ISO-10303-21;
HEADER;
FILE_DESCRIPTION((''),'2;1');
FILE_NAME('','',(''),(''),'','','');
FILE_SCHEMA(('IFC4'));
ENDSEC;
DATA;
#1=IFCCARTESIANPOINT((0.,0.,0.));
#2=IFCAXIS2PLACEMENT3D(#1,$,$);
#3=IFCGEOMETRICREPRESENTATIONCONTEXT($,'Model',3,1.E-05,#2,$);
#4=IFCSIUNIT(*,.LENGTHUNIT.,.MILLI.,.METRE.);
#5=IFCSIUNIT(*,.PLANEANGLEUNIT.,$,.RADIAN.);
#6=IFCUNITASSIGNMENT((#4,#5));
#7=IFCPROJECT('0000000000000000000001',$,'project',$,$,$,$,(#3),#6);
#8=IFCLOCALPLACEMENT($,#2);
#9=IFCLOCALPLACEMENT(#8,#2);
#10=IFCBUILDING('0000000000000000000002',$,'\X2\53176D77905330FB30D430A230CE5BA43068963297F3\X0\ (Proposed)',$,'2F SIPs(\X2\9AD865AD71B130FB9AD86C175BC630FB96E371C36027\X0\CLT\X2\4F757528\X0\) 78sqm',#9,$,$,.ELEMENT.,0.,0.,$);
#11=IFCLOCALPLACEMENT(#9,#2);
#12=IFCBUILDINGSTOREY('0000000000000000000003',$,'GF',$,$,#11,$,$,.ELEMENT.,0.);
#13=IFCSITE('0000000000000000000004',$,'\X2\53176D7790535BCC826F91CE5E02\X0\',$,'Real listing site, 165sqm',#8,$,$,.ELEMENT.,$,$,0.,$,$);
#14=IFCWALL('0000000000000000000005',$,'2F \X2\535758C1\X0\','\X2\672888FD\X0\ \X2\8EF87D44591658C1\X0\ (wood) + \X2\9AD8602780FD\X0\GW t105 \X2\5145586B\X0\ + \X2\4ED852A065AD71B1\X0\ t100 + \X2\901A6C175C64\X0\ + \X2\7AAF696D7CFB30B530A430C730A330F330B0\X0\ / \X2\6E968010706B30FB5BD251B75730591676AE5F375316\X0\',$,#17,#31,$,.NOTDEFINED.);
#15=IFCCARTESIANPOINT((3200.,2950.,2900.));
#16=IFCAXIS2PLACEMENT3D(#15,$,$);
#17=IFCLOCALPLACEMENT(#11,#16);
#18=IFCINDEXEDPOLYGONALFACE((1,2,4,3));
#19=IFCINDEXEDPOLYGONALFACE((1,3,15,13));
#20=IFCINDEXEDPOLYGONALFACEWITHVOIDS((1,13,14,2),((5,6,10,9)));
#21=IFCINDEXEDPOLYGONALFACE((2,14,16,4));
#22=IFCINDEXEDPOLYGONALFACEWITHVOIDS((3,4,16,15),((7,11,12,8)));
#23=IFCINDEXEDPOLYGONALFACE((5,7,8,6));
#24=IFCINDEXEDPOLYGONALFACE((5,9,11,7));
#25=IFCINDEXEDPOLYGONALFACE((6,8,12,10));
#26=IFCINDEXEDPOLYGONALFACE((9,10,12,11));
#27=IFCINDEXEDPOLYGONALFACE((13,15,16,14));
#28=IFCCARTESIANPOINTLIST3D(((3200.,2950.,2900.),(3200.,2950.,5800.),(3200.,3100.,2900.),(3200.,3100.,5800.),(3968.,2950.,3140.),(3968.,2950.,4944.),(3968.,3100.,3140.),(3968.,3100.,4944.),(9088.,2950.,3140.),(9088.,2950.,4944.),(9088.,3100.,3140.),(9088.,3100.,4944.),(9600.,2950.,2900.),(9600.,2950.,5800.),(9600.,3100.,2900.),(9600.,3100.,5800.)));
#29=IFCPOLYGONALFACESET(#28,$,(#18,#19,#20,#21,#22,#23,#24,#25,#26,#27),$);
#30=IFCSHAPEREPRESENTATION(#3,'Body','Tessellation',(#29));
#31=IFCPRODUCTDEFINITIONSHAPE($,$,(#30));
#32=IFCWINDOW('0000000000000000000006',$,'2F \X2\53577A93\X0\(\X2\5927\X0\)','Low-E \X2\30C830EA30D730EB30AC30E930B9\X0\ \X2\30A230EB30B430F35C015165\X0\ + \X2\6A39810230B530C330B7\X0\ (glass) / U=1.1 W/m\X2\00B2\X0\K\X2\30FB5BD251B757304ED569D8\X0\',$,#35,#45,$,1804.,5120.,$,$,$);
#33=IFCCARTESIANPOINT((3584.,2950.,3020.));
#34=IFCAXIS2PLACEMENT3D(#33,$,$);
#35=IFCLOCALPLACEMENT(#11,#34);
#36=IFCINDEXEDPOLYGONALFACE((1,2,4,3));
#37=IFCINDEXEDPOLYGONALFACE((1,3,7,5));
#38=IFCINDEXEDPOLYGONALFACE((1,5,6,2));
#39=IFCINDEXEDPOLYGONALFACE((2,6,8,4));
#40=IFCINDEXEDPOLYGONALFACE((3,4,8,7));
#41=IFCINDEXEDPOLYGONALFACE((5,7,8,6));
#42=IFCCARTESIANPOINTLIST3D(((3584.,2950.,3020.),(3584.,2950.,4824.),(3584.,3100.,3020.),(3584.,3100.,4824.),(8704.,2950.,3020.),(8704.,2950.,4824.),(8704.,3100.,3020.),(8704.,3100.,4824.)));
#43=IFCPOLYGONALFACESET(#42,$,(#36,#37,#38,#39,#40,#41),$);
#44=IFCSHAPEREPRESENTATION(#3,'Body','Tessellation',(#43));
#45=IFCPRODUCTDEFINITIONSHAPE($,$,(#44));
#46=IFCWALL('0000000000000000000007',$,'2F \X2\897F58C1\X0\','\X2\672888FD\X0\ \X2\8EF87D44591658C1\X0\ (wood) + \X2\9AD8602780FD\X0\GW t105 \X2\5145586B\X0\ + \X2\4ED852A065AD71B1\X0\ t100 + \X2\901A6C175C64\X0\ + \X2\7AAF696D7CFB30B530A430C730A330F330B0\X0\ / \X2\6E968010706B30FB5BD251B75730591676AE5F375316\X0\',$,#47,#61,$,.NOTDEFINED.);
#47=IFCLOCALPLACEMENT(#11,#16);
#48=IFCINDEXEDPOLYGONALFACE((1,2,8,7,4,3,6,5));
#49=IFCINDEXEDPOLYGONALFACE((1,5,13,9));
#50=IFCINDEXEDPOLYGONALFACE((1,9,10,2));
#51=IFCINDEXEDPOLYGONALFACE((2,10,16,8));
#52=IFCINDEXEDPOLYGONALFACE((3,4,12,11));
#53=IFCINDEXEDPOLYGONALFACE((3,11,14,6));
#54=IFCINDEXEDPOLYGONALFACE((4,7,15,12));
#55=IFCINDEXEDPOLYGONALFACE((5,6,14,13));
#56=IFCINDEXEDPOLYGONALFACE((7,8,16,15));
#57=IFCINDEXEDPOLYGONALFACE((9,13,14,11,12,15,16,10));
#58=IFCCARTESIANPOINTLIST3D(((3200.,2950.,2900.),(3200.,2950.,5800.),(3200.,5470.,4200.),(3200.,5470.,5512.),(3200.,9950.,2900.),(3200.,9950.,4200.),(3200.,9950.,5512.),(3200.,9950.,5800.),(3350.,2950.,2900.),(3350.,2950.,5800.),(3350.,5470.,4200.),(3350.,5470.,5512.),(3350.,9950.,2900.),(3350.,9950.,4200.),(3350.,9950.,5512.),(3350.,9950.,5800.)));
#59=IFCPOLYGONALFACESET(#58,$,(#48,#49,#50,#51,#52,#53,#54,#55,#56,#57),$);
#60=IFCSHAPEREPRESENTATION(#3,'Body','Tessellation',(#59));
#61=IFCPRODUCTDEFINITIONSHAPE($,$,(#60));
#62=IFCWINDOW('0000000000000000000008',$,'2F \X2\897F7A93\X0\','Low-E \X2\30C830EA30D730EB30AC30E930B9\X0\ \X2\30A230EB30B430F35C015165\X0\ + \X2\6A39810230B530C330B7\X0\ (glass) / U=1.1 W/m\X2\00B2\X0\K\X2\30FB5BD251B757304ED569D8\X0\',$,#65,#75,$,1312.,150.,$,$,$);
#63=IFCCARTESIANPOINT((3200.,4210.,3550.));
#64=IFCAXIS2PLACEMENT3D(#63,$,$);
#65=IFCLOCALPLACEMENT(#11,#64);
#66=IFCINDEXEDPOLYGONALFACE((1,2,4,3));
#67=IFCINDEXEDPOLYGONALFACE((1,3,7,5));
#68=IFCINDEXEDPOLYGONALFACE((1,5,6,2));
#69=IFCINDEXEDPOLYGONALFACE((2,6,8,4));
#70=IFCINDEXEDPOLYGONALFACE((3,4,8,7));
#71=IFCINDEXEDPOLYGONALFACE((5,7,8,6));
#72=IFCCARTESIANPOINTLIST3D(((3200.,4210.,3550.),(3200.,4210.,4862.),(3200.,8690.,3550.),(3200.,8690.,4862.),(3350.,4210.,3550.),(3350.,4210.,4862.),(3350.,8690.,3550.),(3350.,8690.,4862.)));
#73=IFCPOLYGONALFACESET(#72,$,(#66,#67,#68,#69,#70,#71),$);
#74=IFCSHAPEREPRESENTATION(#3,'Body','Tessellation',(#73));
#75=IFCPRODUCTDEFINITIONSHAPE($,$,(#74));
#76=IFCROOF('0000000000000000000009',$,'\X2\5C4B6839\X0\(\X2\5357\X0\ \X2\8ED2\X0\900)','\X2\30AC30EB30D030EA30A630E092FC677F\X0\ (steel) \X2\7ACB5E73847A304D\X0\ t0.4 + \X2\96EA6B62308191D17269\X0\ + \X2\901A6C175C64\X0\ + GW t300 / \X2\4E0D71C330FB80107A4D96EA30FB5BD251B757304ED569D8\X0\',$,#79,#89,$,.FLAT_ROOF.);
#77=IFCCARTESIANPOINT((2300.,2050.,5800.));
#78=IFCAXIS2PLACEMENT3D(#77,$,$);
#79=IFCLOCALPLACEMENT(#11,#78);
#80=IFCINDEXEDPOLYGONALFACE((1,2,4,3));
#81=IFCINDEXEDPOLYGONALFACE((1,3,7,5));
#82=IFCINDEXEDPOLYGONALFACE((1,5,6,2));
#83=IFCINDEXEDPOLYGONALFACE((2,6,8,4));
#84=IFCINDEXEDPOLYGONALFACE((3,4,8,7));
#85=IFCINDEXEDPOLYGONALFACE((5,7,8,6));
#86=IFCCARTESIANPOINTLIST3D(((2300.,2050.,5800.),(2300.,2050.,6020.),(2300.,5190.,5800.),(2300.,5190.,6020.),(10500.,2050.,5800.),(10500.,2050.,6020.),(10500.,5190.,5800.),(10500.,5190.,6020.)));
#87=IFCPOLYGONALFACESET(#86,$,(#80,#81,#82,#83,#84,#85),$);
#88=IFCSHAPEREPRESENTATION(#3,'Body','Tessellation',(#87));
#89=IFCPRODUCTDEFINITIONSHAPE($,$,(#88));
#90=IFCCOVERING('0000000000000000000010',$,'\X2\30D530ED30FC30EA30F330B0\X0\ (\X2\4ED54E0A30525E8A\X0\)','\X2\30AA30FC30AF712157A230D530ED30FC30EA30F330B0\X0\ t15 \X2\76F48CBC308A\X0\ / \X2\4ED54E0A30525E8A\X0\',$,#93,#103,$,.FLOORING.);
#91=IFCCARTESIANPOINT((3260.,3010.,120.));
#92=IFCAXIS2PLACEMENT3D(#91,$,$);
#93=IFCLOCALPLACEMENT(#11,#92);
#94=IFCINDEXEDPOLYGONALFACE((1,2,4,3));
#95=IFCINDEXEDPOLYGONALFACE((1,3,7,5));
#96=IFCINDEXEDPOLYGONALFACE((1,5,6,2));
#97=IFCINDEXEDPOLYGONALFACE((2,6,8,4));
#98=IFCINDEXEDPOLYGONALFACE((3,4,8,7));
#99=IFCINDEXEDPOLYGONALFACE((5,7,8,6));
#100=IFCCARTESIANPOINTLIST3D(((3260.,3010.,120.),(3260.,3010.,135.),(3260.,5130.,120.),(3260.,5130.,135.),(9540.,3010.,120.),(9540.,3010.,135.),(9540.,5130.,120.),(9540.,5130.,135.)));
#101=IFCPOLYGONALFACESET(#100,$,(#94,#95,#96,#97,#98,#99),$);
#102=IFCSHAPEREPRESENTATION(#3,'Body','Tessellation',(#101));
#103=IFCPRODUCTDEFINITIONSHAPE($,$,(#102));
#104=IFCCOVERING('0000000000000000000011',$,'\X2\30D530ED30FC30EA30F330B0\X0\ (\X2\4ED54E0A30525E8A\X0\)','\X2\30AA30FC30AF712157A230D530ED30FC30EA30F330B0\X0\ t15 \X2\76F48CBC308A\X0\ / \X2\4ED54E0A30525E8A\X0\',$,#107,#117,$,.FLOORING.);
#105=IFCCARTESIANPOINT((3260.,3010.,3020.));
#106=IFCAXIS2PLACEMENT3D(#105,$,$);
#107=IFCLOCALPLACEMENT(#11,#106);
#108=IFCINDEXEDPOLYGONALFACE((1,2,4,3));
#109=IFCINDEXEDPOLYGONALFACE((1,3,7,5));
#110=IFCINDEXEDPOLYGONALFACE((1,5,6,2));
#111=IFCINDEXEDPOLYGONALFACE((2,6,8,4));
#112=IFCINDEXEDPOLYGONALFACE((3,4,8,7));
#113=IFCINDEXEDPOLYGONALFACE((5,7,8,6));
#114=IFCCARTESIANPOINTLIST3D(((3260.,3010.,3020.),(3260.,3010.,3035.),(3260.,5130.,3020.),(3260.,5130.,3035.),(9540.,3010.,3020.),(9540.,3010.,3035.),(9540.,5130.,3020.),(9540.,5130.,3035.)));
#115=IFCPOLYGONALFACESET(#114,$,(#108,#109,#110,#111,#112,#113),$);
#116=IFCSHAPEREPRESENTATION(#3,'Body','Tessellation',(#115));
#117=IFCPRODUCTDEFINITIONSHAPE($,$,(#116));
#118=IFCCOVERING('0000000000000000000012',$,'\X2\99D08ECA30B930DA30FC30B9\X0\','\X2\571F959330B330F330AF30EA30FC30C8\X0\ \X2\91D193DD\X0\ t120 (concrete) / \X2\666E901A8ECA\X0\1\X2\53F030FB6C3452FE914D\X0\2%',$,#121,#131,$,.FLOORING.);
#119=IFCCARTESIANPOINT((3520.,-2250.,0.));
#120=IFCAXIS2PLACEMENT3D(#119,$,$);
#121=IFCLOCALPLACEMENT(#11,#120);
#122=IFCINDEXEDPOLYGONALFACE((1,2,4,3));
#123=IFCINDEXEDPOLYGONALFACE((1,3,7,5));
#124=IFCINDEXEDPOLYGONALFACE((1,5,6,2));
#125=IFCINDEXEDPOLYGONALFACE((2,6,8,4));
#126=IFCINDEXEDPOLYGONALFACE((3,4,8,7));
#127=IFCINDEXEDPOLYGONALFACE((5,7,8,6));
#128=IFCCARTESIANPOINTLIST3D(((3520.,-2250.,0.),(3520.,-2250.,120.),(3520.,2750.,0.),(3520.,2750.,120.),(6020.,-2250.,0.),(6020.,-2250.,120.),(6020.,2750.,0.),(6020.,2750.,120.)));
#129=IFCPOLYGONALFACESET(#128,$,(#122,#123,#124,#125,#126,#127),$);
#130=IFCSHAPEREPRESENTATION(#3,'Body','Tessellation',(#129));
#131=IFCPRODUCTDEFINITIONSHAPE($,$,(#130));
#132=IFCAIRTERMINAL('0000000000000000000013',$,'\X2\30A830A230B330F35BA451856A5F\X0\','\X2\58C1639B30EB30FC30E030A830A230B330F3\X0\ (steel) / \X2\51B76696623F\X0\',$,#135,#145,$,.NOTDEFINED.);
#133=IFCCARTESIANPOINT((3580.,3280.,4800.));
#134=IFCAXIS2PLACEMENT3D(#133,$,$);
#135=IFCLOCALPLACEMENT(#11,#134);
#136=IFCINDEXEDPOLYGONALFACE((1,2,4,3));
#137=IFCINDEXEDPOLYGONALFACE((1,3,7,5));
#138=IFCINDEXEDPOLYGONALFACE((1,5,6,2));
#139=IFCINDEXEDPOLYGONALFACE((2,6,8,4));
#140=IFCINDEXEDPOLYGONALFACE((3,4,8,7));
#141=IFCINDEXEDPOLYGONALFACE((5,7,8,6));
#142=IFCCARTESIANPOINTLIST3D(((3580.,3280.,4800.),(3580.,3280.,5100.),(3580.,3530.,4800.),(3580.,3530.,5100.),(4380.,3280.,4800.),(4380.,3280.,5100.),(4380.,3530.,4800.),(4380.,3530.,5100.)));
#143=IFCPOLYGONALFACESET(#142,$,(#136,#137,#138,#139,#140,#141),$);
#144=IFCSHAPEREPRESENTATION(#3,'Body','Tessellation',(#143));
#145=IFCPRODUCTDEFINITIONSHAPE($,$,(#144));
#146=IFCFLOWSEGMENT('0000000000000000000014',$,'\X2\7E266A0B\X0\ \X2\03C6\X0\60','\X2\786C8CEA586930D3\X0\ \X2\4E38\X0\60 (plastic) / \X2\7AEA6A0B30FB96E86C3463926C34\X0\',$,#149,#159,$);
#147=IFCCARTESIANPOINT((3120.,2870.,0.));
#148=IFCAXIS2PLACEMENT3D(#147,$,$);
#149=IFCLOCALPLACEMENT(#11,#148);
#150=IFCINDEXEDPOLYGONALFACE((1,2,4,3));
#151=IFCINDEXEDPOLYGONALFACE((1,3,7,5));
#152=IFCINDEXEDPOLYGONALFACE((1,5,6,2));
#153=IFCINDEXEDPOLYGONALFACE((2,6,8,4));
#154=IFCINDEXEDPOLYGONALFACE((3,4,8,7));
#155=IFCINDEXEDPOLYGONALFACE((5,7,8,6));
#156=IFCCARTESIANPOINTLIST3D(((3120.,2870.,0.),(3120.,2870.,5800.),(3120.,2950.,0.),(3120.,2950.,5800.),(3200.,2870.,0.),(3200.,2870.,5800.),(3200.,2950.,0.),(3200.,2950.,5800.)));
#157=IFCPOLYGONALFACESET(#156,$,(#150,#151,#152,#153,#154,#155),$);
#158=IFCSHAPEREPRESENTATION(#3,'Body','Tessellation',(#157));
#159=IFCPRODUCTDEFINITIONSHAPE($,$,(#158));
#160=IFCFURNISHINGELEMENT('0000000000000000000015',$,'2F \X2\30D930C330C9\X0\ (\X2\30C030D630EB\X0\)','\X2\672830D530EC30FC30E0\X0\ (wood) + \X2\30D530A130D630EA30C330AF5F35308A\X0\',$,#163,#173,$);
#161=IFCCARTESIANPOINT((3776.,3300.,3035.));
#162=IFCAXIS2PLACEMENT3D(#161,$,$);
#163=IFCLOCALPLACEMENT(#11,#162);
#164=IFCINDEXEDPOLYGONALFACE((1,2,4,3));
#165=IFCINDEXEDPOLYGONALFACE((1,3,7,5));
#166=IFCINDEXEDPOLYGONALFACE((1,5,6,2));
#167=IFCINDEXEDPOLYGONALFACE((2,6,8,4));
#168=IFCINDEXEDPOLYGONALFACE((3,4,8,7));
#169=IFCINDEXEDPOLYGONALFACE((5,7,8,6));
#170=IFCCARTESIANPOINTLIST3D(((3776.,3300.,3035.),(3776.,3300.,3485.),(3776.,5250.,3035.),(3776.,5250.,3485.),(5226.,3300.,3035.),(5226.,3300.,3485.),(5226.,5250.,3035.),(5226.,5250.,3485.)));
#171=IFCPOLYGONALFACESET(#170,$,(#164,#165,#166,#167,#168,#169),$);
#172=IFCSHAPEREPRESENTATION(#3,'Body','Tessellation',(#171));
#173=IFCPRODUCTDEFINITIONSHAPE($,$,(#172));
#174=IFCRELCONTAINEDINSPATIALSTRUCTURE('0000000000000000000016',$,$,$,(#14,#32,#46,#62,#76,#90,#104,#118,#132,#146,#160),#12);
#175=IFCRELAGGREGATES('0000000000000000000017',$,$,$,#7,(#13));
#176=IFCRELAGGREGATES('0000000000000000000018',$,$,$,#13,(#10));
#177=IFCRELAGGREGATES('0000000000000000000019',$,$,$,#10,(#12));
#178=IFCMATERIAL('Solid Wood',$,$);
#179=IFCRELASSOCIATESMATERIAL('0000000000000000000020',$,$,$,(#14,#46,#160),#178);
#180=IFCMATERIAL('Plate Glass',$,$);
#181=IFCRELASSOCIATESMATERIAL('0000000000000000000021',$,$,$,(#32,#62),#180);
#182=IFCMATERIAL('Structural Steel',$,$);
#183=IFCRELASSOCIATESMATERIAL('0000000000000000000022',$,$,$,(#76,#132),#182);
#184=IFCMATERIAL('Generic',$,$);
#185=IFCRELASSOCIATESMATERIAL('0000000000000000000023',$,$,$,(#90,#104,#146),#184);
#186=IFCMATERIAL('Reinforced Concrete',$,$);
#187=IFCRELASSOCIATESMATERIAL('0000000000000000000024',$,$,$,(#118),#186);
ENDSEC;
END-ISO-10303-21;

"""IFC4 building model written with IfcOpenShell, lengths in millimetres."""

from ifc_helpers import new_model, si_unit, frame, frame_2d, origin, place, context, project, spatial, rectangle, extrude, material, element, fill, save


model = new_model("IFC4")

# Units and contexts
model_context = context("Model", 3, precision=1e-05, world=origin())
ifc_project = project(units=[si_unit("LENGTHUNIT", "METRE", prefix="MILLI"), si_unit("PLANEANGLEUNIT", "RADIAN")], contexts=[model_context])

# Site, building, storey
site_placement = place(None, origin())
site = spatial("IfcSite", under=ifc_project, at=site_placement, Name="北海道富良野市", ObjectType="Real listing site, 165sqm", CompositionType="ELEMENT", RefElevation=0.0)
building_placement = place(site_placement, origin())
building = spatial("IfcBuilding", under=site, at=building_placement, Name="北海道・ピアノ室と防音 (Proposed)", ObjectType="2F SIPs(高断熱・高気密・難燃性CLT併用) 78sqm", CompositionType="ELEMENT", ElevationOfRefHeight=0.0, ElevationOfTerrain=0.0)
storey_placement = place(building_placement, origin())
storey = spatial("IfcBuildingStorey", under=building, at=storey_placement, Name="GF", CompositionType="ELEMENT", Elevation=0.0)

# Shared definitions
ifc_material_1 = material(Name="Solid Wood")

# Shared definitions
ifc_material_2 = material(Name="Reinforced Concrete")

# Shared definitions
ifc_material_3 = material(Name="Plate Glass")

# Walls, openings, windows
wall_1_placement = place(storey_placement, frame((3200.0, 2950.0, 2900.0)))
wall_1 = element("IfcWall", 1, at=wall_1_placement, inside=storey, material=ifc_material_1, Name="2F 南壁", Description="木製 軸組外壁 (wood) + 高性能GW t105 充填 + 付加断熱 t100 + 通気層 + 窯業系サイディング / 準耐火・寒冷地外皮強化", PredefinedType="NOTDEFINED", context=model_context, shape_type="SweptSolid", body=[
    extrude(rectangle(XDim=6400.0, YDim=150.0, at=frame_2d((3200.0, 75.0))), frame((3200.0, 2950.0, 2900.0)), (0.0, 0.0, 1.0), 2900.0),
])
opening_1_placement = place(storey_placement, frame((3584.0, 2950.0, 3020.0)))
opening_1 = element("IfcOpeningElement", 2, at=opening_1_placement, cuts=wall_1, PredefinedType="NOTDEFINED", context=model_context, shape_type="SweptSolid", body=[
    extrude(rectangle(XDim=5120.0, YDim=150.0, at=frame_2d((2560.0, 75.0))), frame((3584.0, 2950.0, 3020.0)), (0.0, 0.0, 1.0), 1804.0),
])
window_1_placement = place(storey_placement, frame((3584.0, 2950.0, 3020.0)))
window_1 = element("IfcWindow", 3, at=window_1_placement, inside=storey, material=ifc_material_3, Name="2F 南窓(大)", Description="Low-E トリプルガラス アルゴン封入 + 樹脂サッシ (glass) / U=1.1 W/m²K・寒冷地仕様", OverallHeight=1804.0, OverallWidth=5120.0, context=model_context, shape_type="SweptSolid", body=[
    extrude(rectangle(XDim=5120.0, YDim=150.0, at=frame_2d((2560.0, 75.0))), frame((3584.0, 2950.0, 3020.0)), (0.0, 0.0, 1.0), 1804.0),
])
fill(opening_1, window_1)
wall_2_placement = place(storey_placement, frame((3200.0, 2950.0, 2900.0)))
wall_2 = element("IfcWall", 4, at=wall_2_placement, inside=storey, material=ifc_material_1, Name="2F 西壁", Description="木製 軸組外壁 (wood) + 高性能GW t105 充填 + 付加断熱 t100 + 通気層 + 窯業系サイディング / 準耐火・寒冷地外皮強化", PredefinedType="NOTDEFINED", context=model_context, shape_type="SweptSolid", body=[
    extrude(rectangle(XDim=150.0, YDim=7000.0, at=frame_2d((75.0, 3500.0))), frame((3200.0, 2950.0, 2900.0)), (0.0, 0.0, 1.0), 2900.0),
])
opening_2_placement = place(storey_placement, frame((3200.0, 4210.0, 3550.0)))
opening_2 = element("IfcOpeningElement", 5, at=opening_2_placement, cuts=wall_2, PredefinedType="NOTDEFINED", context=model_context, shape_type="SweptSolid", body=[
    extrude(rectangle(XDim=150.0, YDim=4480.0, at=frame_2d((75.0, 2240.0))), frame((3200.0, 4210.0, 3550.0)), (0.0, 0.0, 1.0), 1312.0),
])
window_2_placement = place(storey_placement, frame((3200.0, 4210.0, 3550.0)))
window_2 = element("IfcWindow", 6, at=window_2_placement, inside=storey, material=ifc_material_3, Name="2F 西窓", Description="Low-E トリプルガラス アルゴン封入 + 樹脂サッシ (glass) / U=1.1 W/m²K・寒冷地仕様", OverallHeight=1312.0, OverallWidth=150.0, context=model_context, shape_type="SweptSolid", body=[
    extrude(rectangle(XDim=150.0, YDim=4480.0, at=frame_2d((75.0, 2240.0))), frame((3200.0, 4210.0, 3550.0)), (0.0, 0.0, 1.0), 1312.0),
])
fill(opening_2, window_2)

# Roof
ifc_material_4 = material(Name="Structural Steel")
for number, where, name in (
    (7, (2300.0, 2050.0, 5800.0), "屋根(南 軒900)"),
):
    element("IfcRoof", number, at=place(storey_placement, frame(where)), inside=storey, material=ifc_material_4, Name=name, Description="ガルバリウム鋼板 (steel) 立平葺き t0.4 + 雪止め金物 + 通気層 + GW t300 / 不燃・耐積雪・寒冷地仕様", PredefinedType="FLAT_ROOF", context=model_context, shape_type="SweptSolid", body=[
        extrude(rectangle(XDim=8200.0, YDim=3140.0, at=frame_2d((4100.0, 1570.0))), frame((2300.0, 2050.0, 5800.0)), (0.0, 0.0, 1.0), 220.0),
    ])

# Coverings
ifc_material_5 = material(Name="Generic")
covering_1_placement = place(storey_placement, frame((3260.0, 3010.0, 120.0)))
element("IfcCovering", 8, at=covering_1_placement, inside=storey, material=ifc_material_5, Name="フローリング (仕上げ床)", Description="オーク無垢フローリング t15 直貼り / 仕上げ床", PredefinedType="FLOORING", context=model_context, shape_type="SweptSolid", body=[
    extrude(rectangle(XDim=6280.0, YDim=2120.0, at=frame_2d((3140.0, 1060.0))), frame((3260.0, 3010.0, 120.0)), (0.0, 0.0, 1.0), 15.0),
])
covering_2_placement = place(storey_placement, frame((3260.0, 3010.0, 3020.0)))
element("IfcCovering", 9, at=covering_2_placement, inside=storey, material=ifc_material_5, Name="フローリング (仕上げ床)", Description="オーク無垢フローリング t15 直貼り / 仕上げ床", PredefinedType="FLOORING", context=model_context, shape_type="SweptSolid", body=[
    extrude(rectangle(XDim=6280.0, YDim=2120.0, at=frame_2d((3140.0, 1060.0))), frame((3260.0, 3010.0, 3020.0)), (0.0, 0.0, 1.0), 15.0),
])
covering_3_placement = place(storey_placement, frame((3520.0, -2250.0, 0.0)))
element("IfcCovering", 10, at=covering_3_placement, inside=storey, material=ifc_material_2, Name="駐車スペース", Description="土間コンクリート 金鏝 t120 (concrete) / 普通車1台・水勾配2%", PredefinedType="FLOORING", context=model_context, shape_type="SweptSolid", body=[
    extrude(rectangle(XDim=2500.0, YDim=5000.0, at=frame_2d((1250.0, 2500.0))), frame((3520.0, -2250.0, 0.0)), (0.0, 0.0, 1.0), 120.0),
])

# Air terminal
air_terminal_placement = place(storey_placement, frame((3580.0, 3280.0, 4800.0)))
element("IfcAirTerminal", 11, at=air_terminal_placement, inside=storey, material=ifc_material_4, Name="エアコン室内機", Description="壁掛ルームエアコン (steel) / 冷暖房", PredefinedType="NOTDEFINED", context=model_context, shape_type="SweptSolid", body=[
    extrude(rectangle(XDim=800.0, YDim=250.0, at=frame_2d((400.0, 125.0))), frame((3580.0, 3280.0, 4800.0)), (0.0, 0.0, 1.0), 300.0),
])

# Flow segment
flow_segment_1_placement = place(storey_placement, frame((3120.0, 2870.0, 0.0)))
element("IfcFlowSegment", 12, at=flow_segment_1_placement, inside=storey, material=ifc_material_5, Name="縦樋 φ60", Description="硬質塩ビ 丸60 (plastic) / 竪樋・雨水排水", context=model_context, shape_type="SweptSolid", body=[
    extrude(rectangle(XDim=80.0, YDim=80.0, at=frame_2d((40.0, 40.0))), frame((3120.0, 2870.0, 0.0)), (0.0, 0.0, 1.0), 5800.0),
])

# Furnishing element
furnishing_placement = place(storey_placement, frame((3776.0, 3300.0, 3035.0)))
element("IfcFurnishingElement", 13, at=furnishing_placement, inside=storey, material=ifc_material_1, Name="2F ベッド (ダブル)", Description="木フレーム (wood) + ファブリック張り", context=model_context, shape_type="SweptSolid", body=[
    extrude(rectangle(XDim=1450.0, YDim=1950.0, at=frame_2d((725.0, 975.0))), frame((3776.0, 3300.0, 3035.0)), (0.0, 0.0, 1.0), 450.0),
])

save(model, "model.ifc")
